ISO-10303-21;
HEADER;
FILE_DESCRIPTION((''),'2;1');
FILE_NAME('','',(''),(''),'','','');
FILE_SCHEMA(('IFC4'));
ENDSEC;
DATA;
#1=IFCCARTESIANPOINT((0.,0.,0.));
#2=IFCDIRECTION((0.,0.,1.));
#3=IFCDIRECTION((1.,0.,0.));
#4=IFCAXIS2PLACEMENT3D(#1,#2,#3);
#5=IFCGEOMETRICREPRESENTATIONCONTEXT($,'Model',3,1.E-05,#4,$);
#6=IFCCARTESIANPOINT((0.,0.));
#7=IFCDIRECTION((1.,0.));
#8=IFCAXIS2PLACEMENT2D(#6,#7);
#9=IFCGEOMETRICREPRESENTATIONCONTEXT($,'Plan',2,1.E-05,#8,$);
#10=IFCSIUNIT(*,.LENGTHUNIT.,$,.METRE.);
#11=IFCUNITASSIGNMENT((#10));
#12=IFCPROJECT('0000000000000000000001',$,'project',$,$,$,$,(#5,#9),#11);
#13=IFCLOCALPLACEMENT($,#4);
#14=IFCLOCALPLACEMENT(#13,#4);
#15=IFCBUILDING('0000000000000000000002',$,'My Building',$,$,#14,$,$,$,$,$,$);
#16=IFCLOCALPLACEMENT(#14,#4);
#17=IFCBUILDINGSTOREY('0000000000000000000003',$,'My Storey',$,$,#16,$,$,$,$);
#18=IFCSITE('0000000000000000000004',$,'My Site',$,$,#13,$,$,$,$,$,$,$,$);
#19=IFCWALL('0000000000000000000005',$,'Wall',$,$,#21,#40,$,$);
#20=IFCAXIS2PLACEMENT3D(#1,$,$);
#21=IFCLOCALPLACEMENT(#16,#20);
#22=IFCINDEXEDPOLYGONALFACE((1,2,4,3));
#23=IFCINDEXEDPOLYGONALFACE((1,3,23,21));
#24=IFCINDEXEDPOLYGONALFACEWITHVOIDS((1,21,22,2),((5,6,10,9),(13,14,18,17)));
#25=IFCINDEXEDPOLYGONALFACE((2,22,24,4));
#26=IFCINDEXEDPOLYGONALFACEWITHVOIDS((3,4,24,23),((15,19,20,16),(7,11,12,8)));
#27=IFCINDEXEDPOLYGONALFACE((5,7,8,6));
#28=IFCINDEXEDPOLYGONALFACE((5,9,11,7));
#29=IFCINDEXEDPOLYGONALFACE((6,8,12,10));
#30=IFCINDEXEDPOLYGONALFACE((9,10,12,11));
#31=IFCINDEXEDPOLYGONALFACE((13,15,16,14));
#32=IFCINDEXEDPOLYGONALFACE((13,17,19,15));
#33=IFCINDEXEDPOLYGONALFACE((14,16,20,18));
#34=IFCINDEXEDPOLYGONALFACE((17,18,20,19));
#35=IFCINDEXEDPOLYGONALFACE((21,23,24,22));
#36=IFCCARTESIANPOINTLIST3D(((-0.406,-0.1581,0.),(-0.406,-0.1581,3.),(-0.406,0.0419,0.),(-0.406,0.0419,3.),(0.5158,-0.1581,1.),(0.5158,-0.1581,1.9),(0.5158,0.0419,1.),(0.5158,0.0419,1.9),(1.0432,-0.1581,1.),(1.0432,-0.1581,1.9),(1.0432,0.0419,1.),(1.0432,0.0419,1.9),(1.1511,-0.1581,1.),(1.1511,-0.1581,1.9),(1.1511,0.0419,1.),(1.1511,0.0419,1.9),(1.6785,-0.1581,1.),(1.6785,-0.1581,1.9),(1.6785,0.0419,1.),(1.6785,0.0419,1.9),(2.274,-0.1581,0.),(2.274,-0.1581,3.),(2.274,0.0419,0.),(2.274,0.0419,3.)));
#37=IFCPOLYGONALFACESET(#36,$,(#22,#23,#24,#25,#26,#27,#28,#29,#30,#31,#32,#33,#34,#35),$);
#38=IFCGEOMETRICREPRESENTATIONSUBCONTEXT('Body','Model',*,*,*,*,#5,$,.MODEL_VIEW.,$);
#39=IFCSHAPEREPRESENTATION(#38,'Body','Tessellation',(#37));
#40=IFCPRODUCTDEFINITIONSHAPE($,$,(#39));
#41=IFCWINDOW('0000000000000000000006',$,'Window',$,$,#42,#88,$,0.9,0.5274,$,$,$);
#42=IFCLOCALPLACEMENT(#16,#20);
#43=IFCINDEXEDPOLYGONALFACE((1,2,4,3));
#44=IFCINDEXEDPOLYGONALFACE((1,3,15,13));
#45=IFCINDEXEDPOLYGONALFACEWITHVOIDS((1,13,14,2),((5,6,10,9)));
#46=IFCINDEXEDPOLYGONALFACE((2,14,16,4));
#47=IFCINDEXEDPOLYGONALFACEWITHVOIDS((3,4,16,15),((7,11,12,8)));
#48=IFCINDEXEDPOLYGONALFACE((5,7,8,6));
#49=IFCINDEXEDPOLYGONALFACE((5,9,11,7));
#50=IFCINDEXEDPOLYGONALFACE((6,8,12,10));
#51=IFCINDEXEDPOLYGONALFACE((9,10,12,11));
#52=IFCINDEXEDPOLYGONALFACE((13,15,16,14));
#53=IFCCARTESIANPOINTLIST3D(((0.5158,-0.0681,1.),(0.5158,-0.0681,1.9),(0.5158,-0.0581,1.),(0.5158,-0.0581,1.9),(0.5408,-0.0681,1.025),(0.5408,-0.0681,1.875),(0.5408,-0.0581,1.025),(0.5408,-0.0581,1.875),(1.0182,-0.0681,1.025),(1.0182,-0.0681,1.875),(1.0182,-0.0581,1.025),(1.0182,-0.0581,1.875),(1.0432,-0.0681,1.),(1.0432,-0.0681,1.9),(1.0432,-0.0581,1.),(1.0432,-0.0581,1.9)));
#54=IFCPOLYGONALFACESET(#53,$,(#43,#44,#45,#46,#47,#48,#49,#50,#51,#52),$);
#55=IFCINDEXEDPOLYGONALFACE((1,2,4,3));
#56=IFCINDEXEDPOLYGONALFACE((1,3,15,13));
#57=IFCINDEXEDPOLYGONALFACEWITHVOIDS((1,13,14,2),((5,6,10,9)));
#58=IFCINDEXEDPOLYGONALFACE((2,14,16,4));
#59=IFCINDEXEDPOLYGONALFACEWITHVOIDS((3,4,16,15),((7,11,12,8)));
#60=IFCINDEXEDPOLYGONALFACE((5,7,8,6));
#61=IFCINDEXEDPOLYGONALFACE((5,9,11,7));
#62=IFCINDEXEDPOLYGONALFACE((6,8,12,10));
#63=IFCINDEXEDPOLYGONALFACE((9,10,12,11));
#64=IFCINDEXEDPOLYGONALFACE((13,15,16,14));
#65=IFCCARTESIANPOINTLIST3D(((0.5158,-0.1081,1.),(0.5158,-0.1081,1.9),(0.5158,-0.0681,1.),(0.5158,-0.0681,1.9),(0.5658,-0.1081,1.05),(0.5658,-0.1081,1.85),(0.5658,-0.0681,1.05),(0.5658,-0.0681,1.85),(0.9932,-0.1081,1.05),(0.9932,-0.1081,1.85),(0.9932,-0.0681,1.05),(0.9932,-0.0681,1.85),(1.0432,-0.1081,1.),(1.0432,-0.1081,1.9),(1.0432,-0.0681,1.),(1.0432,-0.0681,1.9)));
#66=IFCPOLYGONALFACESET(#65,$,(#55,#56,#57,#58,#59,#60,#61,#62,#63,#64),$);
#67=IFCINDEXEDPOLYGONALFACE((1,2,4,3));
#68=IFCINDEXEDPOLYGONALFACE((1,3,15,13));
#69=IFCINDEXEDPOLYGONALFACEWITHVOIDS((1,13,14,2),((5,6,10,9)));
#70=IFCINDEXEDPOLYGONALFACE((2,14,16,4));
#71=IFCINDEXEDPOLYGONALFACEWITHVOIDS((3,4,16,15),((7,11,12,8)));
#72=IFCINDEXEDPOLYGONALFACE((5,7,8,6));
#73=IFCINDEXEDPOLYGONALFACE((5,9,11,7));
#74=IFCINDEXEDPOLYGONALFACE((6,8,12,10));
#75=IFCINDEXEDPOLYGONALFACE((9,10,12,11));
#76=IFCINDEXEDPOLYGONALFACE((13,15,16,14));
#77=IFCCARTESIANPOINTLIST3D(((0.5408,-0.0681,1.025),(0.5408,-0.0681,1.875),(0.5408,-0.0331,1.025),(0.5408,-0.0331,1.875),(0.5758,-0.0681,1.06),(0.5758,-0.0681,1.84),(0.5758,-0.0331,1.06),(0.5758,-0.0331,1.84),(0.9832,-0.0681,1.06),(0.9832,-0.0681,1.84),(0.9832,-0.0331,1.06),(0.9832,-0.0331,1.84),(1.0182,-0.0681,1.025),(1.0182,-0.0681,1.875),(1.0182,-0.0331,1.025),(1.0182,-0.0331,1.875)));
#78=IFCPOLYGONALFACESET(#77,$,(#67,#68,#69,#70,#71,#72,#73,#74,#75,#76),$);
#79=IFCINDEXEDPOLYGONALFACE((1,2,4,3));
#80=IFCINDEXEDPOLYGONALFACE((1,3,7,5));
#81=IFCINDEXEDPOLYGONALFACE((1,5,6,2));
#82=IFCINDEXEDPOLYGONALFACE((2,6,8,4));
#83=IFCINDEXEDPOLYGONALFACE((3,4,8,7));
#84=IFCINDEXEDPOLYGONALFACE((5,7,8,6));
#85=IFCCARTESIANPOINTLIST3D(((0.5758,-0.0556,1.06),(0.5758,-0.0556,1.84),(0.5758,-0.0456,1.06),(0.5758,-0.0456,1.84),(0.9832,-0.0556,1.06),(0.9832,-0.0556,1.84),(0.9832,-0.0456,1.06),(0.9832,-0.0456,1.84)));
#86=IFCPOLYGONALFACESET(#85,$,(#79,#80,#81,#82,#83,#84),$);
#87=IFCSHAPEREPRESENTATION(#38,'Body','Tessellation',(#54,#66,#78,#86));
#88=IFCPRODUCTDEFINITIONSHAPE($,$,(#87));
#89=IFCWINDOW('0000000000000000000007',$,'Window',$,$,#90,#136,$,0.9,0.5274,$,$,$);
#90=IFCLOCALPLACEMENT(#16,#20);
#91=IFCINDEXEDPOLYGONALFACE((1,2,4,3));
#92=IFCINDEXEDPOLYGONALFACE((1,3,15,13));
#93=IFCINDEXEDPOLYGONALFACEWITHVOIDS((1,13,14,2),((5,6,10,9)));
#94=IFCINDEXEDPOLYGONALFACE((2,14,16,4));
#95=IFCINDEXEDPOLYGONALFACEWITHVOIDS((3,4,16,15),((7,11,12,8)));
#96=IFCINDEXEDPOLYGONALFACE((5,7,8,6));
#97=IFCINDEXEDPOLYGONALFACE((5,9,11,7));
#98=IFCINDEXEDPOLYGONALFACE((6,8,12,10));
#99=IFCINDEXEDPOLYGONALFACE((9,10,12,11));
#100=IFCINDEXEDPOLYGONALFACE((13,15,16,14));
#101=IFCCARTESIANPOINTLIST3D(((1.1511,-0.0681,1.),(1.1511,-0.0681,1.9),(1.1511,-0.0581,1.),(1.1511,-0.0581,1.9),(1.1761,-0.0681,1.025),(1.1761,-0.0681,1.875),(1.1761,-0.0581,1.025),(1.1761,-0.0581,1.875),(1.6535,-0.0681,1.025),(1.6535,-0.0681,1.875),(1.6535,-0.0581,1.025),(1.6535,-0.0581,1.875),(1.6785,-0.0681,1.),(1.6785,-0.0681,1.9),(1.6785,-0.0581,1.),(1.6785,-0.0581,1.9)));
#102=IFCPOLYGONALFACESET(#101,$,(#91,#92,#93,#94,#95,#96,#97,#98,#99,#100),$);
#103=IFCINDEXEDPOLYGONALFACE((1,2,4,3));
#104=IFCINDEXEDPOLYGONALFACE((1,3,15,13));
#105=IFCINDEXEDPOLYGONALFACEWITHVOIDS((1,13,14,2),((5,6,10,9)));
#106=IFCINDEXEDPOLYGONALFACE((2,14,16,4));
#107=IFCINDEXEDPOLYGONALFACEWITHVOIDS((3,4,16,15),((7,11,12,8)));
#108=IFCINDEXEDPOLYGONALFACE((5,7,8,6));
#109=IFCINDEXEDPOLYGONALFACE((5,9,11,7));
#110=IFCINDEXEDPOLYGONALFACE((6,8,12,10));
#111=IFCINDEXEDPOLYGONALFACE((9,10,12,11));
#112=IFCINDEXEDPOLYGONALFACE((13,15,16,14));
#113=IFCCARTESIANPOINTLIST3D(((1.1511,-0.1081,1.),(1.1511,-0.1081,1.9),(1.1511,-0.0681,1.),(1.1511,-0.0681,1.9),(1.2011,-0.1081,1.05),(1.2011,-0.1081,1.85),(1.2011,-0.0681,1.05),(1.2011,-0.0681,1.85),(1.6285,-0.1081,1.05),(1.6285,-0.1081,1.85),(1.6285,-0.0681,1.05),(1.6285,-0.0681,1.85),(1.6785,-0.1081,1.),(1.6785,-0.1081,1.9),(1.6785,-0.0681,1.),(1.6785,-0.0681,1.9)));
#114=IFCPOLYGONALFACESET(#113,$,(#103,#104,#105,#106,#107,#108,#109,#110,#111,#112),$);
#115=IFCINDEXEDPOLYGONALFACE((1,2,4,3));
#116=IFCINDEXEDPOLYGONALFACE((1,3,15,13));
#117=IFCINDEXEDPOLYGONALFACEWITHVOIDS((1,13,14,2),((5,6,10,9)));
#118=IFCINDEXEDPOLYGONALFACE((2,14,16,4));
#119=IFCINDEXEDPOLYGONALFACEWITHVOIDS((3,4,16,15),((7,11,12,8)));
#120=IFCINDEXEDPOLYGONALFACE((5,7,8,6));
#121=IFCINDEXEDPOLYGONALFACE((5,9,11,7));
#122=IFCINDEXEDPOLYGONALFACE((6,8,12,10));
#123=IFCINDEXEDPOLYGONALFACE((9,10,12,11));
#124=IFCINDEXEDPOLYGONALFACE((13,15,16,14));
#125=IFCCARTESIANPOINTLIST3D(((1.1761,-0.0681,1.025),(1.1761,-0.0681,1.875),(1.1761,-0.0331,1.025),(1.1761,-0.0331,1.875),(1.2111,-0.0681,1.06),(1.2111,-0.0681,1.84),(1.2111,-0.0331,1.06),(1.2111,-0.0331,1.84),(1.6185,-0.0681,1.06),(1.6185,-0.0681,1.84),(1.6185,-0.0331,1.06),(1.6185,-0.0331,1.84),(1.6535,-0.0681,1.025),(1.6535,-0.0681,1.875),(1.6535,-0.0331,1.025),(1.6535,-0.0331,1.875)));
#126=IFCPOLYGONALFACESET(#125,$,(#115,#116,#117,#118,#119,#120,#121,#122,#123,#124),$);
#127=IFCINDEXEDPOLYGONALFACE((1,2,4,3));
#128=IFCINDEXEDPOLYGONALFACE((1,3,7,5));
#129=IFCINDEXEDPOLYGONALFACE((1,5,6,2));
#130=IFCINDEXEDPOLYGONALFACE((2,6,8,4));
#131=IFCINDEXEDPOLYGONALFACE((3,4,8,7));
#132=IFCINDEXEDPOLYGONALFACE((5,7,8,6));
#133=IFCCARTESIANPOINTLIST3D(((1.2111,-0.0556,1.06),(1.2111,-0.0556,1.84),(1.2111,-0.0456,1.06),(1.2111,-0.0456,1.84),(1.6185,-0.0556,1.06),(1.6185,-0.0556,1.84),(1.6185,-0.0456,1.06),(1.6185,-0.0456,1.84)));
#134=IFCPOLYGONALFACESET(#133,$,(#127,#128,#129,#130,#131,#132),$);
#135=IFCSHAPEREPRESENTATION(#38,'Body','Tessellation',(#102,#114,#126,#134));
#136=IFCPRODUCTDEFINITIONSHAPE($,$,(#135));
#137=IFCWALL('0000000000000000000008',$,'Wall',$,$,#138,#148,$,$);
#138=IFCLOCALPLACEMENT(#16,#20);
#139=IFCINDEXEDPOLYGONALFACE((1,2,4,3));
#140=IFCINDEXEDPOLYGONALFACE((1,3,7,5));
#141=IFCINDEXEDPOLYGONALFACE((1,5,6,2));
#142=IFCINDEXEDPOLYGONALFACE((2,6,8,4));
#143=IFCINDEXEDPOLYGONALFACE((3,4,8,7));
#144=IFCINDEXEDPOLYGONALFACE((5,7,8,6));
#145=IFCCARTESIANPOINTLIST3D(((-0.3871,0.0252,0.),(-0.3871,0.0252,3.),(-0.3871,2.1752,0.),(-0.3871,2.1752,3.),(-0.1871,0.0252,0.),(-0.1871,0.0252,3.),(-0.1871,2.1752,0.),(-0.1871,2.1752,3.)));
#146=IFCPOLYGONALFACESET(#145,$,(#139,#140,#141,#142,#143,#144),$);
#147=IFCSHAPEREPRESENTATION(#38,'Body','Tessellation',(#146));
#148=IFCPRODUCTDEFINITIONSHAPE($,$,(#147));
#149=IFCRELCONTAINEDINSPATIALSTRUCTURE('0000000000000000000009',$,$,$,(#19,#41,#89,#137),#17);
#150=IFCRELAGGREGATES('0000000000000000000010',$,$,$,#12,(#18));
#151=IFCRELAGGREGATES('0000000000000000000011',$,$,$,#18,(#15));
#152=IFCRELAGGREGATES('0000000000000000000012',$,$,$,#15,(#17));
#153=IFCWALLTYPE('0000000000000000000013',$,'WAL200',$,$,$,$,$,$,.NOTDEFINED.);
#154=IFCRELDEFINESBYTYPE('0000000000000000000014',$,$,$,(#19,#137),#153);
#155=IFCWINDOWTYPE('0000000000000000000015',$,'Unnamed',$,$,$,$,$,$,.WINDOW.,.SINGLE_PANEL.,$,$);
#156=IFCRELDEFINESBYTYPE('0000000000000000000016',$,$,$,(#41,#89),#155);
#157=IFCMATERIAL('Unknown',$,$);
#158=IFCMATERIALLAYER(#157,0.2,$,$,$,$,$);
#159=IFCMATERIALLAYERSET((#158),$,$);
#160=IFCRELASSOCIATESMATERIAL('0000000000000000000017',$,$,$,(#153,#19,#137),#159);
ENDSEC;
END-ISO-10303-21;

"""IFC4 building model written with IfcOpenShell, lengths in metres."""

from ifc_helpers import new_model, entity, si_unit, frame, origin_with_axes, origin_2d_with_axis, place, context, subcontext, project, spatial, line, indexed_curve, outline, extrude, shape, source, transform, mapped, material, layer, layer_set, layer_usage, type_object, type_shapes, element, fill, save


model = new_model("IFC4")

# Units and contexts
model_context = context("Model", 3, precision=1e-05, world=origin_with_axes())
plan_context = context("Plan", 2, precision=1e-05, world=origin_2d_with_axis())
body_context_1 = subcontext(model_context, "Body", "Model", "MODEL_VIEW")
body_context_2 = subcontext(plan_context, "Body", "Plan", "PLAN_VIEW")
ifc_project = project(units=[si_unit("LENGTHUNIT", "METRE")], contexts=[model_context, plan_context])

# Site, building, storey
site_placement = place(None, origin_with_axes())
site = spatial("IfcSite", under=ifc_project, at=site_placement, Name="My Site")
building_placement = place(site_placement, origin_with_axes())
building = spatial("IfcBuilding", under=site, at=building_placement, Name="My Building")
storey_placement = place(building_placement, origin_with_axes())
storey = spatial("IfcBuildingStorey", under=building, at=storey_placement, Name="My Storey")

# Shared definitions
ifc_material = material(Name="Unknown")

# Wall, openings, windows
ifc_layer_1 = layer(ifc_material, 0.2)
ifc_layer_set_1 = layer_set([ifc_layer_1])
ifc_layer_usage_1 = layer_usage(ifc_layer_set_1, "AXIS2", "POSITIVE", 0.0)
wall_type_1 = type_object("IfcWallType", Name="WAL200", PredefinedType="NOTDEFINED", material=ifc_layer_set_1)
wall_1_placement = place(storey_placement, frame((2.274, 0.0419, 0.0), z_axis=(0.0, 0.0, 1.0), x_axis=(-1.0, 0.0, 0.0)))
wall_1 = element("IfcWall", 1, at=wall_1_placement, inside=storey, type_object=wall_type_1, material=ifc_layer_usage_1, Name="Wall", context=body_context_1, shape_type="SweptSolid", body=[
    extrude(outline(indexed_curve([(0.0, 0.0), (0.0, 0.2), (2.68, 0.2), (2.68, 0.0)], segments=[line(1, 2, 3, 4, 1)])), origin_with_axes(), (0.0, 0.0, 1.0), 3.0),
])
shared_shape_1 = source(origin_with_axes(), body_context_1, "Body", "SweptSolid", [
    extrude(outline(indexed_curve([(0.0, 0.0), (0.5274, 0.0), (0.5274, 0.9), (0.0, 0.9)], segments=[line(1, 2, 3, 4, 1)])), frame((0.0, -0.6, 0.0), z_axis=(0.0, -1.0, 0.0), x_axis=(1.0, 0.0, 0.0)), (0.0, 0.0, -1.0), 1.2),
])
opening_1_placement = place(wall_1_placement, frame((1.7582, 0.2, 1.0), z_axis=(0.0, 0.0, 1.0), x_axis=(-1.0, 0.0, 0.0)))
opening_1 = element("IfcOpeningElement", 2, at=opening_1_placement, cuts=wall_1, PredefinedType="OPENING", context=body_context_1, shape_type="MappedRepresentation", body=[
    mapped(shared_shape_1, transform((0.0, 0.0, 0.0), x_axis=(1.0, 0.0, 0.0), y_axis=(0.0, 1.0, 0.0), z_axis=(0.0, 0.0, 1.0), scale=1.0)),
])
opening_2_placement = place(wall_1_placement, frame((1.1229, 0.2, 1.0), z_axis=(0.0, 0.0, 1.0), x_axis=(-1.0, 0.0, 0.0)))
opening_2 = element("IfcOpeningElement", 3, at=opening_2_placement, cuts=wall_1, PredefinedType="OPENING", context=body_context_1, shape_type="MappedRepresentation", body=[
    mapped(shared_shape_1, transform((0.0, 0.0, 0.0), x_axis=(1.0, 0.0, 0.0), y_axis=(0.0, 1.0, 0.0), z_axis=(0.0, 0.0, 1.0), scale=1.0)),
])
window_type_1 = type_object("IfcWindowType", Name="Unnamed", PartitioningType="SINGLE_PANEL", PredefinedType="WINDOW")
shared_shape_2 = source(origin_with_axes(), body_context_1, "Body", "SweptSolid", [
    extrude(outline(indexed_curve([(0.0, 0.0), (0.5274, 0.0), (0.5274, 0.9), (0.0, 0.9)], segments=[line(1, 2, 3, 4, 1)]), holes=[indexed_curve([(0.025, 0.025), (0.5024, 0.025), (0.5024, 0.875), (0.025, 0.875)], segments=[line(1, 2, 3, 4, 1)])]), frame((0.0, 0.09, 0.0), z_axis=(0.0, -1.0, 0.0), x_axis=(1.0, 0.0, 0.0)), (0.0, 0.0, -1.0), 0.01),
    extrude(outline(indexed_curve([(0.0, 0.0), (0.5274, 0.0), (0.5274, 0.9), (0.0, 0.9)], segments=[line(1, 2, 3, 4, 1)]), holes=[indexed_curve([(0.05, 0.05), (0.4774, 0.05), (0.4774, 0.85), (0.05, 0.85)], segments=[line(1, 2, 3, 4, 1)])]), frame((0.0, 0.05, 0.0), z_axis=(0.0, -1.0, 0.0), x_axis=(1.0, 0.0, 0.0)), (0.0, 0.0, -1.0), 0.04),
    extrude(outline(indexed_curve([(0.0, 0.0), (0.4774, 0.0), (0.4774, 0.85), (0.0, 0.85)], segments=[line(1, 2, 3, 4, 1)]), holes=[indexed_curve([(0.035, 0.035), (0.4424, 0.035), (0.4424, 0.815), (0.035, 0.815)], segments=[line(1, 2, 3, 4, 1)])]), frame((0.025, 0.09, 0.025), z_axis=(0.0, -1.0, 0.0), x_axis=(1.0, 0.0, 0.0)), (0.0, 0.0, -1.0), 0.035),
    extrude(outline(indexed_curve([(0.035, 0.035), (0.4424, 0.035), (0.4424, 0.815), (0.035, 0.815)], segments=[line(1, 2, 3, 4, 1)])), frame((0.025, 0.1025, 0.025), z_axis=(0.0, -1.0, 0.0), x_axis=(1.0, 0.0, 0.0)), (0.0, 0.0, -1.0), 0.01),
])
shared_shape_3 = source(origin_with_axes(), body_context_2, "Body", "Curve2D", [
    entity("IfcIndexedPolyCurve", entity("IfcCartesianPointList2D", [[0.05, 0.05], [0.4774, 0.05]])),
    entity("IfcIndexedPolyCurve", entity("IfcCartesianPointList2D", [[0.0, 0.1], [0.025, 0.1], [0.025, 0.09], [0.05, 0.09], [0.05, 0.05], [0.0, 0.05]]), [entity("IfcLineIndex", [1, 2, 3, 4, 5, 6, 1])]),
    entity("IfcIndexedPolyCurve", entity("IfcCartesianPointList2D", [[0.5274, 0.1], [0.5024, 0.1], [0.5024, 0.09], [0.4774, 0.09], [0.4774, 0.05], [0.5274, 0.05]]), [entity("IfcLineIndex", [1, 2, 3, 4, 5, 6, 1])]),
    entity("IfcIndexedPolyCurve", entity("IfcCartesianPointList2D", [[0.025, 0.09], [0.06, 0.09], [0.06, 0.125], [0.025, 0.125]]), [entity("IfcLineIndex", [1, 2, 3, 4, 1])]),
    entity("IfcIndexedPolyCurve", entity("IfcCartesianPointList2D", [[0.5024, 0.09], [0.4674, 0.09], [0.4674, 0.125], [0.5024, 0.125]]), [entity("IfcLineIndex", [1, 2, 3, 4, 1])]),
    entity("IfcIndexedPolyCurve", entity("IfcCartesianPointList2D", [[0.06, 0.09], [0.4674, 0.09]])),
    entity("IfcIndexedPolyCurve", entity("IfcCartesianPointList2D", [[0.06, 0.125], [0.4674, 0.125]])),
    entity("IfcIndexedPolyCurve", entity("IfcCartesianPointList2D", [[0.06, 0.1075], [0.4674, 0.1075]])),
])
type_shapes(window_type_1, [shared_shape_2, shared_shape_3])
window_1_placement = place(opening_1_placement, frame((0.0, 0.0, 0.0), z_axis=(0.0, 0.0, 1.0), x_axis=(1.0, 0.0, 0.0)))
window_1 = element("IfcWindow", 4, at=window_1_placement, inside=storey, type_object=window_type_1, Name="Window", OverallHeight=0.9, OverallWidth=0.5274, shapes=[
    shape(body_context_1, "Body", "MappedRepresentation", [mapped(shared_shape_2, transform((0.0, 0.0, 0.0), x_axis=(1.0, 0.0, 0.0), y_axis=(0.0, 1.0, 0.0), z_axis=(0.0, 0.0, 1.0), scale=1.0))]),
    shape(body_context_2, "Body", "MappedRepresentation", [mapped(shared_shape_3, transform((0.0, 0.0, 0.0), x_axis=(1.0, 0.0, 0.0), y_axis=(0.0, 1.0, 0.0), z_axis=(0.0, 0.0, 1.0), scale=1.0))]),
])
fill(opening_1, window_1)
window_2_placement = place(opening_2_placement, frame((0.0, 0.0, 0.0), z_axis=(0.0, 0.0, 1.0), x_axis=(1.0, 0.0, 0.0)))
window_2 = element("IfcWindow", 5, at=window_2_placement, inside=storey, type_object=window_type_1, Name="Window", OverallHeight=0.9, OverallWidth=0.5274, shapes=[
    shape(body_context_1, "Body", "MappedRepresentation", [mapped(shared_shape_2, transform((0.0, 0.0, 0.0), x_axis=(1.0, 0.0, 0.0), y_axis=(0.0, 1.0, 0.0), z_axis=(0.0, 0.0, 1.0), scale=1.0))]),
    shape(body_context_2, "Body", "MappedRepresentation", [mapped(shared_shape_3, transform((0.0, 0.0, 0.0), x_axis=(1.0, 0.0, 0.0), y_axis=(0.0, 1.0, 0.0), z_axis=(0.0, 0.0, 1.0), scale=1.0))]),
])
fill(opening_2, window_2)

# Wall
ifc_layer_usage_2 = layer_usage(ifc_layer_set_1, "AXIS2", "POSITIVE", 0.0)
wall_2_placement = place(storey_placement, frame((-0.1871, 0.0252, 0.0), z_axis=(0.0, 0.0, 1.0), x_axis=(0.0, 1.0, 0.0)))
element("IfcWall", 6, at=wall_2_placement, inside=storey, type_object=wall_type_1, material=ifc_layer_usage_2, Name="Wall", context=body_context_1, shape_type="SweptSolid", body=[
    extrude(outline(indexed_curve([(0.0, 0.0), (0.0, 0.2), (2.15, 0.2), (2.15, 0.0)], segments=[line(1, 2, 3, 4, 1)])), origin_with_axes(), (0.0, 0.0, 1.0), 3.0),
])

save(model, "model.ifc")
